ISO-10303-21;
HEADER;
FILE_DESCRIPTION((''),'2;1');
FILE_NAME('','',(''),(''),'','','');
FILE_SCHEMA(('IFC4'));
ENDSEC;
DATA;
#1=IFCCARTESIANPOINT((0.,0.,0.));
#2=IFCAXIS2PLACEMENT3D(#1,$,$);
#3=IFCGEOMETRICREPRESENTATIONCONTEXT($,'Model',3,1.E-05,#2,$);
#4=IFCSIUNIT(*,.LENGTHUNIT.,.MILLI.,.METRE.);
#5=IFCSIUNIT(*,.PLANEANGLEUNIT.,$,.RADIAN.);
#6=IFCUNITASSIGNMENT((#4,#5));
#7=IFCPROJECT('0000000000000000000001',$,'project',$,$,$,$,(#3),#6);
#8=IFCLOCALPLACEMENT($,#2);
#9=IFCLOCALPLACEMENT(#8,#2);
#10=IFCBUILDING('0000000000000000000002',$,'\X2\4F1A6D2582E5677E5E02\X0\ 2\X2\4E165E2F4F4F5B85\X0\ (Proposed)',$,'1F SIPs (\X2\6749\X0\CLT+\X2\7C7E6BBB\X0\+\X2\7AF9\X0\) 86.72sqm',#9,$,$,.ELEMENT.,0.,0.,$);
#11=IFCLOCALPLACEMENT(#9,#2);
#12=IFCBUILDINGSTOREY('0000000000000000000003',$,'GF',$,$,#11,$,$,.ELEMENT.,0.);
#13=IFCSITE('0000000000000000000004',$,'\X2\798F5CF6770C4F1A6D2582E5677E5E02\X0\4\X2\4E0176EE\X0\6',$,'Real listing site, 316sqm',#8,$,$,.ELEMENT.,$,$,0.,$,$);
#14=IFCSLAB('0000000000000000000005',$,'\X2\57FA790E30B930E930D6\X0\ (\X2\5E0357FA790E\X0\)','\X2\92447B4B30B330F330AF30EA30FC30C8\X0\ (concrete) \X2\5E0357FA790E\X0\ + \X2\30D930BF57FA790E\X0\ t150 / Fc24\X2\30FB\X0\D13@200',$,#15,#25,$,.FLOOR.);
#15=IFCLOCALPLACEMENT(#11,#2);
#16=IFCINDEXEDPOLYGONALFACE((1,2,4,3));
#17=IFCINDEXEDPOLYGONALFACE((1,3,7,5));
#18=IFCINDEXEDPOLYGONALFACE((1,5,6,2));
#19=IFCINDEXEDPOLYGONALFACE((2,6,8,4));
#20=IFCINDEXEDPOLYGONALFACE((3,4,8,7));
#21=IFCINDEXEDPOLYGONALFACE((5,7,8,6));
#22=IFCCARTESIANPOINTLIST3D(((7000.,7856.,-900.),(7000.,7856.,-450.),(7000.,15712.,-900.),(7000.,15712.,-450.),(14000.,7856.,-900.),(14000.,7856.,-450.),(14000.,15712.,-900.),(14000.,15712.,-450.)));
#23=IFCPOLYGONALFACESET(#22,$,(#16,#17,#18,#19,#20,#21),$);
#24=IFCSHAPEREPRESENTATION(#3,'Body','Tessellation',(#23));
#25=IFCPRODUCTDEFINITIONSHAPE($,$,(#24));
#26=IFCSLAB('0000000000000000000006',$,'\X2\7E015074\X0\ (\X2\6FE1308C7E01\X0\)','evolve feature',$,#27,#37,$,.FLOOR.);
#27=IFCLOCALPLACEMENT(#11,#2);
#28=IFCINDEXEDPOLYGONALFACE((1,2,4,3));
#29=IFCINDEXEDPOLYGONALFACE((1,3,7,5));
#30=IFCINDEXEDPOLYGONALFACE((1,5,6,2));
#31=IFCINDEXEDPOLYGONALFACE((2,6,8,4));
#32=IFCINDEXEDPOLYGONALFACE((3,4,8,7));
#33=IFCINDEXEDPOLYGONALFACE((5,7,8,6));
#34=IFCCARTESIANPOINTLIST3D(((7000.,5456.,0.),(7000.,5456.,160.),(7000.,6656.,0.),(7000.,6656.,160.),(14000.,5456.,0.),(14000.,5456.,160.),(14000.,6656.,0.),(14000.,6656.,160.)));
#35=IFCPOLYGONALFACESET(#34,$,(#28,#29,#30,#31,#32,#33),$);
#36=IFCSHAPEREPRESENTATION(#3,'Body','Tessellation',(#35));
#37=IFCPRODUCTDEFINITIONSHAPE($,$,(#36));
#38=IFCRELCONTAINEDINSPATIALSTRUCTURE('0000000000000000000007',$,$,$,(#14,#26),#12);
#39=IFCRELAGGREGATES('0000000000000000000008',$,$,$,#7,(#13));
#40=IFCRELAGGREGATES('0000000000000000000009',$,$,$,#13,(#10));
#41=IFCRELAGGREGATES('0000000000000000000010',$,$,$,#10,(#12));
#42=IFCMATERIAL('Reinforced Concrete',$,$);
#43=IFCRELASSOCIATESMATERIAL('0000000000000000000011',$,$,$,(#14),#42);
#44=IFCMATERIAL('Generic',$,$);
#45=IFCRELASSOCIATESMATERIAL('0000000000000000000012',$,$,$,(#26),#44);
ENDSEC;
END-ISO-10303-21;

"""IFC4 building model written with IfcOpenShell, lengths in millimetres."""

from ifc_helpers import new_model, si_unit, frame, frame_2d, origin, place, context, project, spatial, rectangle, extrude, material, element, save


model = new_model("IFC4")

# Units and contexts
model_context = context("Model", 3, precision=1e-05, world=origin())
ifc_project = project(units=[si_unit("LENGTHUNIT", "METRE", prefix="MILLI"), si_unit("PLANEANGLEUNIT", "RADIAN")], contexts=[model_context])

# Site, building, storey
site_placement = place(None, origin())
site = spatial("IfcSite", under=ifc_project, at=site_placement, Name="福島県会津若松市4丁目6", ObjectType="Real listing site, 316sqm", CompositionType="ELEMENT", RefElevation=0.0)
building_placement = place(site_placement, origin())
building = spatial("IfcBuilding", under=site, at=building_placement, Name="会津若松市 2世帯住宅 (Proposed)", ObjectType="1F SIPs (杉CLT+籾殻+竹) 86.72sqm", CompositionType="ELEMENT", ElevationOfRefHeight=0.0, ElevationOfTerrain=0.0)
storey_placement = place(building_placement, origin())
storey = spatial("IfcBuildingStorey", under=building, at=storey_placement, Name="GF", CompositionType="ELEMENT", Elevation=0.0)

# Slabs
ifc_material_1 = material(Name="Reinforced Concrete")
slab_1_placement = place(storey_placement, frame((3500.0, 3928.0, -450.0)))
element("IfcSlab", 1, at=slab_1_placement, inside=storey, material=ifc_material_1, Name="基礎スラブ (布基礎)", Description="鉄筋コンクリート (concrete) 布基礎 + ベタ基礎 t150 / Fc24・D13@200", PredefinedType="FLOOR", context=model_context, shape_type="SweptSolid", body=[
    extrude(rectangle(XDim=7000.0, YDim=7856.0, at=frame_2d((3500.0, 3928.0))), frame((3500.0, 3928.0, -450.0)), (0.0, 0.0, 1.0), 450.0),
])
ifc_material_2 = material(Name="Generic")
slab_2_placement = place(storey_placement, frame((3500.0, 2728.0, 0.0)))
element("IfcSlab", 2, at=slab_2_placement, inside=storey, material=ifc_material_2, Name="縁側 (濡れ縁)", Description="evolve feature", PredefinedType="FLOOR", context=model_context, shape_type="SweptSolid", body=[
    extrude(rectangle(XDim=7000.0, YDim=1200.0, at=frame_2d((3500.0, 600.0))), frame((3500.0, 2728.0, 0.0)), (0.0, 0.0, 1.0), 160.0),
])

save(model, "model.ifc")
